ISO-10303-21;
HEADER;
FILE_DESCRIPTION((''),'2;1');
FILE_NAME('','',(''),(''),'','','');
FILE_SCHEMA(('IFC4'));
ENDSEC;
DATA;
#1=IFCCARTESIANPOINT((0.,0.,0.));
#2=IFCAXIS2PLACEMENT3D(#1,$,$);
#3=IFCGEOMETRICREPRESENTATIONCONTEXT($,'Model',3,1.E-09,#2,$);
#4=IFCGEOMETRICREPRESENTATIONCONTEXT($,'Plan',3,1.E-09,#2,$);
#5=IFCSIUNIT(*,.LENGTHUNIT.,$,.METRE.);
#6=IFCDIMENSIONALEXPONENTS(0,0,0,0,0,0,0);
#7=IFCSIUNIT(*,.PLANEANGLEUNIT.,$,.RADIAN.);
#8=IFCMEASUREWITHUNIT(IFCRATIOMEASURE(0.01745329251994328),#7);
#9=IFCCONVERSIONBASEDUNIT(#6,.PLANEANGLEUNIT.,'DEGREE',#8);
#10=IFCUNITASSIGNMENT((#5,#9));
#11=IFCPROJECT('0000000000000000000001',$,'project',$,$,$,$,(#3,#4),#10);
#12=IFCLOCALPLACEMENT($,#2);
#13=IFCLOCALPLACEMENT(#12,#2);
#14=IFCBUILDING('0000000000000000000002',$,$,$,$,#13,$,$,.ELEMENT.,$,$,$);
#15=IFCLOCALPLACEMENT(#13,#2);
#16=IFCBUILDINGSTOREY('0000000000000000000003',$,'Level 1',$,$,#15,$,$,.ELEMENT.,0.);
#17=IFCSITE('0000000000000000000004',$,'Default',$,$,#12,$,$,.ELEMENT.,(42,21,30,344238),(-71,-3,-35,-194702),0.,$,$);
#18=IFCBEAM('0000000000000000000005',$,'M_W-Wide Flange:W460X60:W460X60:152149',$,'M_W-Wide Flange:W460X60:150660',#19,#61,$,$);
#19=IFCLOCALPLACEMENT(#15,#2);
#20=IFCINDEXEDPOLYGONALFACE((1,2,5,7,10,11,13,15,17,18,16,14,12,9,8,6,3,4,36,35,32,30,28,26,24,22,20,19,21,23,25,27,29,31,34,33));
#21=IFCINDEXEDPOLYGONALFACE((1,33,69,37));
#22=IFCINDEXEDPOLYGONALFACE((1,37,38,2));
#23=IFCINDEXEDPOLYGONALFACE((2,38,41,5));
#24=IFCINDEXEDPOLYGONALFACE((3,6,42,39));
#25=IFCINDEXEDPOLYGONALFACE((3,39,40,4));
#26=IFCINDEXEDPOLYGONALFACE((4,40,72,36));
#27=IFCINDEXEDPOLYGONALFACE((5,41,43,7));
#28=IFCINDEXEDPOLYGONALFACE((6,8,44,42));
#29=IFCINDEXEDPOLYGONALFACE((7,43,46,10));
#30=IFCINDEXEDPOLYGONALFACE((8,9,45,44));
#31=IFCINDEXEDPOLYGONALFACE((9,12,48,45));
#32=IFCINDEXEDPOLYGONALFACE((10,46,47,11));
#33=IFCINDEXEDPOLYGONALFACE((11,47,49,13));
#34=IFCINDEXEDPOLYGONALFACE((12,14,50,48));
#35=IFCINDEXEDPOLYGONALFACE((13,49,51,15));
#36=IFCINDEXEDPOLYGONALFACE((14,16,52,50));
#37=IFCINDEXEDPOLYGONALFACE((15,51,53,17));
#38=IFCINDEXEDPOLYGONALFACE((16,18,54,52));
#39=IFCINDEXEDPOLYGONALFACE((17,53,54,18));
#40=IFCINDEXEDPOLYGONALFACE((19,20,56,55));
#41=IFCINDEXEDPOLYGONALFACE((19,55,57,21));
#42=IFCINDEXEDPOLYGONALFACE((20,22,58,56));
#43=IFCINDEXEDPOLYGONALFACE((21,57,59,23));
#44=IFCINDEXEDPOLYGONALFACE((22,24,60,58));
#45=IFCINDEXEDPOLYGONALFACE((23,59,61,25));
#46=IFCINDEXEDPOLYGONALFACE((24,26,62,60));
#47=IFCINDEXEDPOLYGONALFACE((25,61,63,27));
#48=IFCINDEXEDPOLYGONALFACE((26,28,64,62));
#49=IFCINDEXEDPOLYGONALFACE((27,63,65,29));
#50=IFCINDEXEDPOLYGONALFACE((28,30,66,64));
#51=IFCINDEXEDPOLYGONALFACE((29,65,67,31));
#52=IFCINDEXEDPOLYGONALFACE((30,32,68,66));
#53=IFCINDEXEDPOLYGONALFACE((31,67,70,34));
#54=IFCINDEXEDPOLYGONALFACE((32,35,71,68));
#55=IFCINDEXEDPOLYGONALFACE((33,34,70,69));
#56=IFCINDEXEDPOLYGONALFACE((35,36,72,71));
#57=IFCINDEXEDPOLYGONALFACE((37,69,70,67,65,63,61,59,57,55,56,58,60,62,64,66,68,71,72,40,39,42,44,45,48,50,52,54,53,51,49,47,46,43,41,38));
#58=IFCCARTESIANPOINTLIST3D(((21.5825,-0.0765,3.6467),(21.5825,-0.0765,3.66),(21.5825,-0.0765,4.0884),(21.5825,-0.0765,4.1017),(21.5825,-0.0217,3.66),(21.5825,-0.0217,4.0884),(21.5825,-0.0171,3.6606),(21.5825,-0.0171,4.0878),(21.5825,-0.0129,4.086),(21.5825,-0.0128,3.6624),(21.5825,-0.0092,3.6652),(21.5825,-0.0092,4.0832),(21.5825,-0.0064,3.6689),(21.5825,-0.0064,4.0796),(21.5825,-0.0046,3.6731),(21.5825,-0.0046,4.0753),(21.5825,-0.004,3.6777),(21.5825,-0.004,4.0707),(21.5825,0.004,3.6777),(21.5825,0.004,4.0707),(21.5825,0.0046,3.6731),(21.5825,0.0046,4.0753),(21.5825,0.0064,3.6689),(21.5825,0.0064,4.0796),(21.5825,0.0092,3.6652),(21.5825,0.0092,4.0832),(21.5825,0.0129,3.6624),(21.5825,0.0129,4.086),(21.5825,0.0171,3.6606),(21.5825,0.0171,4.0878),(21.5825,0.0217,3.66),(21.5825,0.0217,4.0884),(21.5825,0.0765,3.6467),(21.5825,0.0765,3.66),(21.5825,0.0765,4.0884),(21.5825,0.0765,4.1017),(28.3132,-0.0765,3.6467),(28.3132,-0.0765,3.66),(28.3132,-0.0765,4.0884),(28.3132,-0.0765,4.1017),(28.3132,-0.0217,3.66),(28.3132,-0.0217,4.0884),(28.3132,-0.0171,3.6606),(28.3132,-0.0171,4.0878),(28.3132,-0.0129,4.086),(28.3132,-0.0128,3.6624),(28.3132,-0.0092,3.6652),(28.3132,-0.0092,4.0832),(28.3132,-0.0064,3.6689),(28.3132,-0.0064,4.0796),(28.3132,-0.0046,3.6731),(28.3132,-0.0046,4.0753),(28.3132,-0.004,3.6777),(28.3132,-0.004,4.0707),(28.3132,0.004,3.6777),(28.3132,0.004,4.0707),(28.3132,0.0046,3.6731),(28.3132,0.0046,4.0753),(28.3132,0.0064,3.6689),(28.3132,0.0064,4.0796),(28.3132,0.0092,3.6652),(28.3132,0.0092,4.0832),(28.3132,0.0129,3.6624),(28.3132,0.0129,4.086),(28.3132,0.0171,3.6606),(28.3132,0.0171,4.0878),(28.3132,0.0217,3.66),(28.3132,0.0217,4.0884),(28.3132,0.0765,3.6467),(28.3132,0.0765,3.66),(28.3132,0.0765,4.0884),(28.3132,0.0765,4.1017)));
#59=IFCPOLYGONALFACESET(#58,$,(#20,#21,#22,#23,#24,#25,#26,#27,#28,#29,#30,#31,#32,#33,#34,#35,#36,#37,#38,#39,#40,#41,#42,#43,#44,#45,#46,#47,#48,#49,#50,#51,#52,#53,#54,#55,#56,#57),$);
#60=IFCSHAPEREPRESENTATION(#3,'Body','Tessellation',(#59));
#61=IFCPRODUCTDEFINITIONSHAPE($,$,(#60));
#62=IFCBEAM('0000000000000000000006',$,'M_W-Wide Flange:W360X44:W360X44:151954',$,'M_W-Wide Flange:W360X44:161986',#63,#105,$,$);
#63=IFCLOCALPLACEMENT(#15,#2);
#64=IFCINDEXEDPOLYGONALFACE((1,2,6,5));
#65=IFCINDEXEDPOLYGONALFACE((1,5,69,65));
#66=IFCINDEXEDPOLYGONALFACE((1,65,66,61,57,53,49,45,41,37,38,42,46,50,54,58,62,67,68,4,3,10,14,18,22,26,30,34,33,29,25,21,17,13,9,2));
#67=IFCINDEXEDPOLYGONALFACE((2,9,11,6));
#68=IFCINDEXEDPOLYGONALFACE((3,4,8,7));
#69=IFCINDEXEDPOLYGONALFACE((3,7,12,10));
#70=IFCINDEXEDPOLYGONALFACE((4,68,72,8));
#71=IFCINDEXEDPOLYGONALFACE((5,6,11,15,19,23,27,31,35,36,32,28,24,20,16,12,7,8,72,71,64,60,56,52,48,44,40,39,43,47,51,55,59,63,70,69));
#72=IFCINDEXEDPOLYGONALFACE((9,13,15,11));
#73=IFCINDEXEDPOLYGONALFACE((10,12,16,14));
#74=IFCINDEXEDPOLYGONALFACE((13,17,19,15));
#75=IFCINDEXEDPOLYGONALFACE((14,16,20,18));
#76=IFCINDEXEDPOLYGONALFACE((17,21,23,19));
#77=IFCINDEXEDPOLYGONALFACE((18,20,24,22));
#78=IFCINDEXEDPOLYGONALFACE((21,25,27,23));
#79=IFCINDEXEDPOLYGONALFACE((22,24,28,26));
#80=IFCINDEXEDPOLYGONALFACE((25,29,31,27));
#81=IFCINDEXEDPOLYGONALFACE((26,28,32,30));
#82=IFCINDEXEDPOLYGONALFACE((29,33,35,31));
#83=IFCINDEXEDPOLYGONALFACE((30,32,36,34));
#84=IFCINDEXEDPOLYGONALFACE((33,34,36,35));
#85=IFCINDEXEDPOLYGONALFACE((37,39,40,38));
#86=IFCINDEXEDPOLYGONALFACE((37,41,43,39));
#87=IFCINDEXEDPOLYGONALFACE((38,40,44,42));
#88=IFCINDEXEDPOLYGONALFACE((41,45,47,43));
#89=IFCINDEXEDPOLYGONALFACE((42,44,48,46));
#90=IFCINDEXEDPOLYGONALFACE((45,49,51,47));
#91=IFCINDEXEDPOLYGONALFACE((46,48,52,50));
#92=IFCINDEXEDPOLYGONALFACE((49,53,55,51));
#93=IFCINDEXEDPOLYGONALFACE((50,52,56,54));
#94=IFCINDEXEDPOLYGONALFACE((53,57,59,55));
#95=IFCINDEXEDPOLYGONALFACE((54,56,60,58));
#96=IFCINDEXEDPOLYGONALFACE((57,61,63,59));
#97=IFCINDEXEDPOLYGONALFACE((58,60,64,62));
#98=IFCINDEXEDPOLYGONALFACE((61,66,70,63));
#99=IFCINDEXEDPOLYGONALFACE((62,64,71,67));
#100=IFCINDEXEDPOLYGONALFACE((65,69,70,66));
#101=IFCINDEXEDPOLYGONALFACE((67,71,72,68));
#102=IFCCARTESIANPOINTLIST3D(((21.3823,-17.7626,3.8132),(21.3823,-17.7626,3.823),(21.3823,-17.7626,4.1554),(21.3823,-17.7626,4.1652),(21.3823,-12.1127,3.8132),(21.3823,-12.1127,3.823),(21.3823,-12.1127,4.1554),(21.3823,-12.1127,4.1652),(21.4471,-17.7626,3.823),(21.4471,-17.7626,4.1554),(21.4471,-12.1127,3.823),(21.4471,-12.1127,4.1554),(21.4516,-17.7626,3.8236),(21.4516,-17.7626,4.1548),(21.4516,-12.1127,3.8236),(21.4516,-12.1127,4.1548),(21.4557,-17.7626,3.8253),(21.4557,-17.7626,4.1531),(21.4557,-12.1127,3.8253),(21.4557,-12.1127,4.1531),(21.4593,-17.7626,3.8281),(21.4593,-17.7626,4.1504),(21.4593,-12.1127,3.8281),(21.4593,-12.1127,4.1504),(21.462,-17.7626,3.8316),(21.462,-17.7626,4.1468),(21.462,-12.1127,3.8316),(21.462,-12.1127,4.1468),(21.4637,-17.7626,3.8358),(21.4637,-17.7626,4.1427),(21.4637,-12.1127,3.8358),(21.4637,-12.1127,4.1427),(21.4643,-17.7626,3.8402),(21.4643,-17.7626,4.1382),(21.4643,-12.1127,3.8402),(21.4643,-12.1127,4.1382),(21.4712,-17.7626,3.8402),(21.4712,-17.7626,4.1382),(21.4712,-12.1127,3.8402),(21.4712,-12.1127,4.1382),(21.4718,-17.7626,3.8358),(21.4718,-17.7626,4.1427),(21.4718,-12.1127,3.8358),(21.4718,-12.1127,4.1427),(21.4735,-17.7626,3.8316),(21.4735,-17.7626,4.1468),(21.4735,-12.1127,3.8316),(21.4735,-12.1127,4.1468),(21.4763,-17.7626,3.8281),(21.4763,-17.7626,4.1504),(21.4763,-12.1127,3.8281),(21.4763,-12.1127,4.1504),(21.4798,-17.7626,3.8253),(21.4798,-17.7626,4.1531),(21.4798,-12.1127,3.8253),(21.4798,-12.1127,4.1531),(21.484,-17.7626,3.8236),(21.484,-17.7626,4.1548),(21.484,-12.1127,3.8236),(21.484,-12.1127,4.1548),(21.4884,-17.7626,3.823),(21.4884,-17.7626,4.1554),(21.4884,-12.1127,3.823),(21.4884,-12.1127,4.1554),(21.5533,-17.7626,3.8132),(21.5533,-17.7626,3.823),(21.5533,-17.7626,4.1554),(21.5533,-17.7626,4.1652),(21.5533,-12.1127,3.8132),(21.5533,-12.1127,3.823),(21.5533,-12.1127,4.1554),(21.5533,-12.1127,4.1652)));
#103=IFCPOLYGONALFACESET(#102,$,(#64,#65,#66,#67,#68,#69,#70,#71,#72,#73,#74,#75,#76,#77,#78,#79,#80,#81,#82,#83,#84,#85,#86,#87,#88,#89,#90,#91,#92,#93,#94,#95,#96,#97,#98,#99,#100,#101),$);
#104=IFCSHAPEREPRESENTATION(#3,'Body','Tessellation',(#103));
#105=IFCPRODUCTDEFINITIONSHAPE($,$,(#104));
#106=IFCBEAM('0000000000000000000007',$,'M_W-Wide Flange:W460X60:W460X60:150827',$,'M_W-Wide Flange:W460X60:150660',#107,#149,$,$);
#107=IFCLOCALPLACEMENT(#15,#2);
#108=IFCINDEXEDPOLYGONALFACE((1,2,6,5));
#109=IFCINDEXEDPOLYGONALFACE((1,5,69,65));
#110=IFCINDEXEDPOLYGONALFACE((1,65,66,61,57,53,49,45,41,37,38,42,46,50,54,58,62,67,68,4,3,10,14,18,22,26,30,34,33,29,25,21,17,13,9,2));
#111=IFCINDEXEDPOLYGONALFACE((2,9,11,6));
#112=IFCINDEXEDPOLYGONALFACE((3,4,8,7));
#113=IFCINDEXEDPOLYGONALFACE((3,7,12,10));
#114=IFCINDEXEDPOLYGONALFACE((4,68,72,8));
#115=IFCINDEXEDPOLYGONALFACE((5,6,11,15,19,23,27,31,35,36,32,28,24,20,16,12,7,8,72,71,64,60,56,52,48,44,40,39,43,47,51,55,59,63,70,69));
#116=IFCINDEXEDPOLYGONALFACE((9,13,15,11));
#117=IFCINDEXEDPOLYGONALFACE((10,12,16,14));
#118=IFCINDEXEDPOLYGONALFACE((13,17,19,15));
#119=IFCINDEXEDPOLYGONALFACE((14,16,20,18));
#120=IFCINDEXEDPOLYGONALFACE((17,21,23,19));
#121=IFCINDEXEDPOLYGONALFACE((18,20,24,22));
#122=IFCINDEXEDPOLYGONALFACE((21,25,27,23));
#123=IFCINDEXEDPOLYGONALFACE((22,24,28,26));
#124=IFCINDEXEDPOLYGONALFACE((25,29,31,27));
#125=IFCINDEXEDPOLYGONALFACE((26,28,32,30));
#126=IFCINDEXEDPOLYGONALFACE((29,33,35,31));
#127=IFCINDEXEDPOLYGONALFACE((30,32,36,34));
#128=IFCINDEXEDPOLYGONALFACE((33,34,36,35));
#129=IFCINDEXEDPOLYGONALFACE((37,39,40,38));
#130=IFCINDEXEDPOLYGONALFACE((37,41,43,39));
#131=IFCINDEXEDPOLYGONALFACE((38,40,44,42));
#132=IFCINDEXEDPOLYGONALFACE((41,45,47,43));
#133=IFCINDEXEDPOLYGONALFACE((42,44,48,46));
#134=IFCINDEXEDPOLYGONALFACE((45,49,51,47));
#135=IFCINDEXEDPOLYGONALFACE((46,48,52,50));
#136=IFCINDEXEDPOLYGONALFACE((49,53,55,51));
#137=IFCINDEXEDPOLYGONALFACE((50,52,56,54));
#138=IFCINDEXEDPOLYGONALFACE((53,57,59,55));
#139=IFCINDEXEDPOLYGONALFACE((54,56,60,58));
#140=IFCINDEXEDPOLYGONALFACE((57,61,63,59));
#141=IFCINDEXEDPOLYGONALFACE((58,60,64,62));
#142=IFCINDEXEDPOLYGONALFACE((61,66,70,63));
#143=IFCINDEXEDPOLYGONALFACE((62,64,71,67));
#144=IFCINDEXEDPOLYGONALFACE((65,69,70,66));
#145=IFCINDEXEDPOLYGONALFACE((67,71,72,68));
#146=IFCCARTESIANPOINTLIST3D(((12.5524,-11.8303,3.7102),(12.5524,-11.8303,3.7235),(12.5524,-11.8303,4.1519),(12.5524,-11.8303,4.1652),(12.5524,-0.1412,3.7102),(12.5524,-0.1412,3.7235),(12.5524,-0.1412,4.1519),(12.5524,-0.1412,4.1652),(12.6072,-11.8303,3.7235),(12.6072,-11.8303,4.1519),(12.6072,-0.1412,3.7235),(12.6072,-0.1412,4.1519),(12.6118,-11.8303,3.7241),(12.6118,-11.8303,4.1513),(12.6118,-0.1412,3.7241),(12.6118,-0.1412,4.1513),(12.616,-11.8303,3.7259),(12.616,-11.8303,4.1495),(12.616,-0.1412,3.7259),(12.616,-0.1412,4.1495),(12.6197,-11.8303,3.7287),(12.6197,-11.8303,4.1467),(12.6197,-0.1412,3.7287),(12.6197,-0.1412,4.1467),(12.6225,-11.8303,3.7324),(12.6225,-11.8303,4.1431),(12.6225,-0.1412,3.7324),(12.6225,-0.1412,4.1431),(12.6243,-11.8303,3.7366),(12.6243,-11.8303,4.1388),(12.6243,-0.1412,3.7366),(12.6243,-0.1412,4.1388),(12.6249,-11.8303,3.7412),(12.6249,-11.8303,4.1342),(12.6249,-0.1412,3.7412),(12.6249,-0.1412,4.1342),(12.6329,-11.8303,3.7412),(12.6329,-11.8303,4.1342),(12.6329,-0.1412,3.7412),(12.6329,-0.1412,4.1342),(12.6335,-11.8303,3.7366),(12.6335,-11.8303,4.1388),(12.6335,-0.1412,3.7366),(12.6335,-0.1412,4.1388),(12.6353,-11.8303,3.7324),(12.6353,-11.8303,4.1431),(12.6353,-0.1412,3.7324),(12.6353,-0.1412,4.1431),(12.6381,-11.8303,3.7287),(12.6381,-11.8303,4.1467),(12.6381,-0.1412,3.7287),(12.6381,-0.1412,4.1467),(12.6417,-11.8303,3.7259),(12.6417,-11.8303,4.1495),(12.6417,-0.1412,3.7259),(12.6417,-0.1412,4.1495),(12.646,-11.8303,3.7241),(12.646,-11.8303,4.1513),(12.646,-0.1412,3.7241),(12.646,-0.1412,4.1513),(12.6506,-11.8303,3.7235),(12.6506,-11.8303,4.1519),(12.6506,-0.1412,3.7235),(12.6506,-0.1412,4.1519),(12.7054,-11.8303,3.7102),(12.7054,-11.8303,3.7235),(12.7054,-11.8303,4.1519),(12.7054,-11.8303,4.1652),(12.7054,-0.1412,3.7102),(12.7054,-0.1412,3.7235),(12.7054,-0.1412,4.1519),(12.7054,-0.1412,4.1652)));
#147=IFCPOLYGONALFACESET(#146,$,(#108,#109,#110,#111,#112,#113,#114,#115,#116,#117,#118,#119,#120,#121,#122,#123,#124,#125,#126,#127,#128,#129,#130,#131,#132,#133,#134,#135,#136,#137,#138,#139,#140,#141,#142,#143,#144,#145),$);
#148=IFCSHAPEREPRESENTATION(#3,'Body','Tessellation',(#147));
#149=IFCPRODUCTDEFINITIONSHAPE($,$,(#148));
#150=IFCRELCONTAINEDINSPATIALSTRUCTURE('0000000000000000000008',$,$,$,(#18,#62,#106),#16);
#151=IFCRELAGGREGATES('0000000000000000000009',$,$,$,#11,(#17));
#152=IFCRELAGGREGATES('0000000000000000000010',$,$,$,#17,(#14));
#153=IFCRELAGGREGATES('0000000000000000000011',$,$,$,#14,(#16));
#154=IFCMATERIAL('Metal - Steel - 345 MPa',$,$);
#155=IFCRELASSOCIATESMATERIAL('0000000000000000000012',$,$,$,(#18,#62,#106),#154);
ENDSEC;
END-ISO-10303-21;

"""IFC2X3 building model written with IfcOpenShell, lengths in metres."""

from ifc_helpers import new_model, entity, si_unit, converted_unit, frame, frame_2d, origin, place, context, project, spatial, polyline, circle_curve, parameter, trimmed, segment, composite_curve, outline, extrude, material, element, save


model = new_model("IFC2X3")

# Units and contexts
model_context = context("Model", 3, precision=1e-09, world=origin())
plan_context = context("Plan", 3, precision=1e-09, world=origin())
ifc_project = project(units=[si_unit("LENGTHUNIT", "METRE"), converted_unit("PLANEANGLEUNIT", "DEGREE", entity("IfcRatioMeasure", 0.01745329251994328), si_unit("PLANEANGLEUNIT", "RADIAN"), dimensions=[0, 0, 0, 0, 0, 0, 0])], contexts=[model_context, plan_context])

# Site, building, storey
site_placement = place(None, origin())
site = spatial("IfcSite", under=ifc_project, at=site_placement, Name="Default", CompositionType="ELEMENT", RefLatitude=(42, 21, 30, 344238), RefLongitude=(-71, -3, -35, -194702), RefElevation=0.0)
building_placement = place(site_placement, origin())
building = spatial("IfcBuilding", under=site, at=building_placement, CompositionType="ELEMENT")
storey_placement = place(building_placement, origin())
storey = spatial("IfcBuildingStorey", under=building, at=storey_placement, Name="Level 1", CompositionType="ELEMENT", Elevation=0.0)

# Beams
ifc_material_1 = material(Name="Metal - Steel - 345 MPa")
beam_1_placement = place(storey_placement, frame((21.4678, 0.0, 4.2672), z_axis=(0.0, 0.0, 1.0), x_axis=(0.0, -1.0, 0.0)))
element("IfcBeam", 1, at=beam_1_placement, inside=storey, material=ifc_material_1, Name="M_W-Wide Flange:W460X60:W460X60:152149", ObjectType="M_W-Wide Flange:W460X60:150660", context=model_context, shape_type="SweptSolid", body=[
    extrude(outline(composite_curve([segment(polyline([(-0.0765, -0.2142), (-0.0765, -0.2275)]), True, "CONTINUOUS"), segment(polyline([(-0.0765, -0.2275), (0.0765, -0.2275)]), True, "CONTINUOUS"), segment(polyline([(0.0765, -0.2275), (0.0765, -0.2142)]), True, "CONTINUOUS"), segment(polyline([(0.0765, -0.2142), (0.0217, -0.2142)]), True, "CONTINUOUS"), segment(trimmed(circle_curve(frame_2d((0.0217, -0.1965), x_axis=(0.0, -1.0)), 0.0177), [parameter(270.0)], [parameter(360.0)], True, "PARAMETER"), False, "CONTINUOUS"), segment(polyline([(0.004, -0.1965), (0.004, 0.1965)]), True, "CONTINUOUS"), segment(trimmed(circle_curve(frame_2d((0.0217, 0.1965), x_axis=(-1.0, 0.0)), 0.0177), [parameter(270.0)], [parameter(360.0)], True, "PARAMETER"), False, "CONTINUOUS"), segment(polyline([(0.0217, 0.2142), (0.0765, 0.2142)]), True, "CONTINUOUS"), segment(polyline([(0.0765, 0.2142), (0.0765, 0.2275)]), True, "CONTINUOUS"), segment(polyline([(0.0765, 0.2275), (-0.0765, 0.2275)]), True, "CONTINUOUS"), segment(polyline([(-0.0765, 0.2275), (-0.0765, 0.2142)]), True, "CONTINUOUS"), segment(polyline([(-0.0765, 0.2142), (-0.0217, 0.2142)]), True, "CONTINUOUS"), segment(trimmed(circle_curve(frame_2d((-0.0217, 0.1965), x_axis=(0.0, 1.0)), 0.0177), [parameter(270.0)], [parameter(360.0)], True, "PARAMETER"), False, "CONTINUOUS"), segment(polyline([(-0.004, 0.1965), (-0.004, -0.1965)]), True, "CONTINUOUS"), segment(trimmed(circle_curve(frame_2d((-0.0217, -0.1965), x_axis=(1.0, 0.0)), 0.0177), [parameter(270.0)], [parameter(0.0)], True, "PARAMETER"), False, "CONTINUOUS"), segment(polyline([(-0.0217, -0.2142), (-0.0765, -0.2142)]), True, "CONTINUOUS")], self_intersect=False)), frame((0.0, 0.1147, -0.393), z_axis=(0.0, -1.0, 0.0), x_axis=(1.0, 0.0, 0.0)), (0.0, 0.0, -1.0), 6.7307),
])
beam_2_placement = place(storey_placement, frame((21.4678, -17.9038, 4.2672)))
element("IfcBeam", 2, at=beam_2_placement, inside=storey, material=ifc_material_1, Name="M_W-Wide Flange:W360X44:W360X44:151954", ObjectType="M_W-Wide Flange:W360X44:161986", context=model_context, shape_type="SweptSolid", body=[
    extrude(outline(composite_curve([segment(polyline([(-0.0855, -0.1662), (-0.0855, -0.176)]), True, "CONTINUOUS"), segment(polyline([(-0.0855, -0.176), (0.0855, -0.176)]), True, "CONTINUOUS"), segment(polyline([(0.0855, -0.176), (0.0855, -0.1662)]), True, "CONTINUOUS"), segment(polyline([(0.0855, -0.1662), (0.0207, -0.1662)]), True, "CONTINUOUS"), segment(trimmed(circle_curve(frame_2d((0.0207, -0.149), x_axis=(1.0, 0.0)), 0.0172), [parameter(180.0)], [parameter(270.0)], True, "PARAMETER"), False, "CONTINUOUS"), segment(polyline([(0.0035, -0.149), (0.0035, 0.149)]), True, "CONTINUOUS"), segment(trimmed(circle_curve(frame_2d((0.0207, 0.149), x_axis=(1.0, 0.0)), 0.0172), [parameter(90.0)], [parameter(180.0)], True, "PARAMETER"), False, "CONTINUOUS"), segment(polyline([(0.0207, 0.1662), (0.0855, 0.1662)]), True, "CONTINUOUS"), segment(polyline([(0.0855, 0.1662), (0.0855, 0.176)]), True, "CONTINUOUS"), segment(polyline([(0.0855, 0.176), (-0.0855, 0.176)]), True, "CONTINUOUS"), segment(polyline([(-0.0855, 0.176), (-0.0855, 0.1662)]), True, "CONTINUOUS"), segment(polyline([(-0.0855, 0.1662), (-0.0206, 0.1662)]), True, "CONTINUOUS"), segment(trimmed(circle_curve(frame_2d((-0.0206, 0.149), x_axis=(1.0, 0.0)), 0.0172), [parameter(360.0)], [parameter(90.0)], True, "PARAMETER"), False, "CONTINUOUS"), segment(polyline([(-0.0034, 0.149), (-0.0034, -0.149)]), True, "CONTINUOUS"), segment(trimmed(circle_curve(frame_2d((-0.0206, -0.149), x_axis=(1.0, 0.0)), 0.0172), [parameter(270.0)], [parameter(0.0)], True, "PARAMETER"), False, "CONTINUOUS"), segment(polyline([(-0.0206, -0.1662), (-0.0855, -0.1662)]), True, "CONTINUOUS")], self_intersect=False)), frame((0.0, 0.1412, -0.278), z_axis=(0.0, -1.0, 0.0), x_axis=(1.0, 0.0, 0.0)), (0.0, 0.0, -1.0), 5.65),
])
beam_3_placement = place(storey_placement, frame((12.6289, 0.0, 4.2672), z_axis=(0.0, 0.0, 1.0), x_axis=(-1.0, 0.0, 0.0)))
element("IfcBeam", 3, at=beam_3_placement, inside=storey, material=ifc_material_1, Name="M_W-Wide Flange:W460X60:W460X60:150827", ObjectType="M_W-Wide Flange:W460X60:150660", context=model_context, shape_type="SweptSolid", body=[
    extrude(outline(composite_curve([segment(polyline([(0.2142, -0.0765), (0.2275, -0.0765)]), True, "CONTINUOUS"), segment(polyline([(0.2275, -0.0765), (0.2275, 0.0765)]), True, "CONTINUOUS"), segment(polyline([(0.2275, 0.0765), (0.2142, 0.0765)]), True, "CONTINUOUS"), segment(polyline([(0.2142, 0.0765), (0.2142, 0.0217)]), True, "CONTINUOUS"), segment(trimmed(circle_curve(frame_2d((0.1965, 0.0217), x_axis=(0.0, 1.0)), 0.0177), [parameter(180.0)], [parameter(270.0)], True, "PARAMETER"), False, "CONTINUOUS"), segment(polyline([(0.1965, 0.004), (-0.1965, 0.004)]), True, "CONTINUOUS"), segment(trimmed(circle_curve(frame_2d((-0.1965, 0.0217), x_axis=(0.0, 1.0)), 0.0177), [parameter(90.0)], [parameter(180.0)], True, "PARAMETER"), False, "CONTINUOUS"), segment(polyline([(-0.2142, 0.0217), (-0.2142, 0.0765)]), True, "CONTINUOUS"), segment(polyline([(-0.2142, 0.0765), (-0.2275, 0.0765)]), True, "CONTINUOUS"), segment(polyline([(-0.2275, 0.0765), (-0.2275, -0.0765)]), True, "CONTINUOUS"), segment(polyline([(-0.2275, -0.0765), (-0.2142, -0.0765)]), True, "CONTINUOUS"), segment(polyline([(-0.2142, -0.0765), (-0.2142, -0.0217)]), True, "CONTINUOUS"), segment(trimmed(circle_curve(frame_2d((-0.1965, -0.0217), x_axis=(0.0, 1.0)), 0.0177), [parameter(360.0)], [parameter(90.0)], True, "PARAMETER"), False, "CONTINUOUS"), segment(polyline([(-0.1965, -0.004), (0.1965, -0.004)]), True, "CONTINUOUS"), segment(trimmed(circle_curve(frame_2d((0.1965, -0.0217), x_axis=(0.0, 1.0)), 0.0177), [parameter(270.0)], [parameter(0.0)], True, "PARAMETER"), False, "CONTINUOUS"), segment(polyline([(0.2142, -0.0217), (0.2142, -0.0765)]), True, "CONTINUOUS")], self_intersect=False)), frame((0.0, 11.8303, -0.3295), z_axis=(0.0, -1.0, 0.0), x_axis=(0.0, 0.0, -1.0)), (0.0, 0.0, 1.0), 11.6891),
])

save(model, "model.ifc")
